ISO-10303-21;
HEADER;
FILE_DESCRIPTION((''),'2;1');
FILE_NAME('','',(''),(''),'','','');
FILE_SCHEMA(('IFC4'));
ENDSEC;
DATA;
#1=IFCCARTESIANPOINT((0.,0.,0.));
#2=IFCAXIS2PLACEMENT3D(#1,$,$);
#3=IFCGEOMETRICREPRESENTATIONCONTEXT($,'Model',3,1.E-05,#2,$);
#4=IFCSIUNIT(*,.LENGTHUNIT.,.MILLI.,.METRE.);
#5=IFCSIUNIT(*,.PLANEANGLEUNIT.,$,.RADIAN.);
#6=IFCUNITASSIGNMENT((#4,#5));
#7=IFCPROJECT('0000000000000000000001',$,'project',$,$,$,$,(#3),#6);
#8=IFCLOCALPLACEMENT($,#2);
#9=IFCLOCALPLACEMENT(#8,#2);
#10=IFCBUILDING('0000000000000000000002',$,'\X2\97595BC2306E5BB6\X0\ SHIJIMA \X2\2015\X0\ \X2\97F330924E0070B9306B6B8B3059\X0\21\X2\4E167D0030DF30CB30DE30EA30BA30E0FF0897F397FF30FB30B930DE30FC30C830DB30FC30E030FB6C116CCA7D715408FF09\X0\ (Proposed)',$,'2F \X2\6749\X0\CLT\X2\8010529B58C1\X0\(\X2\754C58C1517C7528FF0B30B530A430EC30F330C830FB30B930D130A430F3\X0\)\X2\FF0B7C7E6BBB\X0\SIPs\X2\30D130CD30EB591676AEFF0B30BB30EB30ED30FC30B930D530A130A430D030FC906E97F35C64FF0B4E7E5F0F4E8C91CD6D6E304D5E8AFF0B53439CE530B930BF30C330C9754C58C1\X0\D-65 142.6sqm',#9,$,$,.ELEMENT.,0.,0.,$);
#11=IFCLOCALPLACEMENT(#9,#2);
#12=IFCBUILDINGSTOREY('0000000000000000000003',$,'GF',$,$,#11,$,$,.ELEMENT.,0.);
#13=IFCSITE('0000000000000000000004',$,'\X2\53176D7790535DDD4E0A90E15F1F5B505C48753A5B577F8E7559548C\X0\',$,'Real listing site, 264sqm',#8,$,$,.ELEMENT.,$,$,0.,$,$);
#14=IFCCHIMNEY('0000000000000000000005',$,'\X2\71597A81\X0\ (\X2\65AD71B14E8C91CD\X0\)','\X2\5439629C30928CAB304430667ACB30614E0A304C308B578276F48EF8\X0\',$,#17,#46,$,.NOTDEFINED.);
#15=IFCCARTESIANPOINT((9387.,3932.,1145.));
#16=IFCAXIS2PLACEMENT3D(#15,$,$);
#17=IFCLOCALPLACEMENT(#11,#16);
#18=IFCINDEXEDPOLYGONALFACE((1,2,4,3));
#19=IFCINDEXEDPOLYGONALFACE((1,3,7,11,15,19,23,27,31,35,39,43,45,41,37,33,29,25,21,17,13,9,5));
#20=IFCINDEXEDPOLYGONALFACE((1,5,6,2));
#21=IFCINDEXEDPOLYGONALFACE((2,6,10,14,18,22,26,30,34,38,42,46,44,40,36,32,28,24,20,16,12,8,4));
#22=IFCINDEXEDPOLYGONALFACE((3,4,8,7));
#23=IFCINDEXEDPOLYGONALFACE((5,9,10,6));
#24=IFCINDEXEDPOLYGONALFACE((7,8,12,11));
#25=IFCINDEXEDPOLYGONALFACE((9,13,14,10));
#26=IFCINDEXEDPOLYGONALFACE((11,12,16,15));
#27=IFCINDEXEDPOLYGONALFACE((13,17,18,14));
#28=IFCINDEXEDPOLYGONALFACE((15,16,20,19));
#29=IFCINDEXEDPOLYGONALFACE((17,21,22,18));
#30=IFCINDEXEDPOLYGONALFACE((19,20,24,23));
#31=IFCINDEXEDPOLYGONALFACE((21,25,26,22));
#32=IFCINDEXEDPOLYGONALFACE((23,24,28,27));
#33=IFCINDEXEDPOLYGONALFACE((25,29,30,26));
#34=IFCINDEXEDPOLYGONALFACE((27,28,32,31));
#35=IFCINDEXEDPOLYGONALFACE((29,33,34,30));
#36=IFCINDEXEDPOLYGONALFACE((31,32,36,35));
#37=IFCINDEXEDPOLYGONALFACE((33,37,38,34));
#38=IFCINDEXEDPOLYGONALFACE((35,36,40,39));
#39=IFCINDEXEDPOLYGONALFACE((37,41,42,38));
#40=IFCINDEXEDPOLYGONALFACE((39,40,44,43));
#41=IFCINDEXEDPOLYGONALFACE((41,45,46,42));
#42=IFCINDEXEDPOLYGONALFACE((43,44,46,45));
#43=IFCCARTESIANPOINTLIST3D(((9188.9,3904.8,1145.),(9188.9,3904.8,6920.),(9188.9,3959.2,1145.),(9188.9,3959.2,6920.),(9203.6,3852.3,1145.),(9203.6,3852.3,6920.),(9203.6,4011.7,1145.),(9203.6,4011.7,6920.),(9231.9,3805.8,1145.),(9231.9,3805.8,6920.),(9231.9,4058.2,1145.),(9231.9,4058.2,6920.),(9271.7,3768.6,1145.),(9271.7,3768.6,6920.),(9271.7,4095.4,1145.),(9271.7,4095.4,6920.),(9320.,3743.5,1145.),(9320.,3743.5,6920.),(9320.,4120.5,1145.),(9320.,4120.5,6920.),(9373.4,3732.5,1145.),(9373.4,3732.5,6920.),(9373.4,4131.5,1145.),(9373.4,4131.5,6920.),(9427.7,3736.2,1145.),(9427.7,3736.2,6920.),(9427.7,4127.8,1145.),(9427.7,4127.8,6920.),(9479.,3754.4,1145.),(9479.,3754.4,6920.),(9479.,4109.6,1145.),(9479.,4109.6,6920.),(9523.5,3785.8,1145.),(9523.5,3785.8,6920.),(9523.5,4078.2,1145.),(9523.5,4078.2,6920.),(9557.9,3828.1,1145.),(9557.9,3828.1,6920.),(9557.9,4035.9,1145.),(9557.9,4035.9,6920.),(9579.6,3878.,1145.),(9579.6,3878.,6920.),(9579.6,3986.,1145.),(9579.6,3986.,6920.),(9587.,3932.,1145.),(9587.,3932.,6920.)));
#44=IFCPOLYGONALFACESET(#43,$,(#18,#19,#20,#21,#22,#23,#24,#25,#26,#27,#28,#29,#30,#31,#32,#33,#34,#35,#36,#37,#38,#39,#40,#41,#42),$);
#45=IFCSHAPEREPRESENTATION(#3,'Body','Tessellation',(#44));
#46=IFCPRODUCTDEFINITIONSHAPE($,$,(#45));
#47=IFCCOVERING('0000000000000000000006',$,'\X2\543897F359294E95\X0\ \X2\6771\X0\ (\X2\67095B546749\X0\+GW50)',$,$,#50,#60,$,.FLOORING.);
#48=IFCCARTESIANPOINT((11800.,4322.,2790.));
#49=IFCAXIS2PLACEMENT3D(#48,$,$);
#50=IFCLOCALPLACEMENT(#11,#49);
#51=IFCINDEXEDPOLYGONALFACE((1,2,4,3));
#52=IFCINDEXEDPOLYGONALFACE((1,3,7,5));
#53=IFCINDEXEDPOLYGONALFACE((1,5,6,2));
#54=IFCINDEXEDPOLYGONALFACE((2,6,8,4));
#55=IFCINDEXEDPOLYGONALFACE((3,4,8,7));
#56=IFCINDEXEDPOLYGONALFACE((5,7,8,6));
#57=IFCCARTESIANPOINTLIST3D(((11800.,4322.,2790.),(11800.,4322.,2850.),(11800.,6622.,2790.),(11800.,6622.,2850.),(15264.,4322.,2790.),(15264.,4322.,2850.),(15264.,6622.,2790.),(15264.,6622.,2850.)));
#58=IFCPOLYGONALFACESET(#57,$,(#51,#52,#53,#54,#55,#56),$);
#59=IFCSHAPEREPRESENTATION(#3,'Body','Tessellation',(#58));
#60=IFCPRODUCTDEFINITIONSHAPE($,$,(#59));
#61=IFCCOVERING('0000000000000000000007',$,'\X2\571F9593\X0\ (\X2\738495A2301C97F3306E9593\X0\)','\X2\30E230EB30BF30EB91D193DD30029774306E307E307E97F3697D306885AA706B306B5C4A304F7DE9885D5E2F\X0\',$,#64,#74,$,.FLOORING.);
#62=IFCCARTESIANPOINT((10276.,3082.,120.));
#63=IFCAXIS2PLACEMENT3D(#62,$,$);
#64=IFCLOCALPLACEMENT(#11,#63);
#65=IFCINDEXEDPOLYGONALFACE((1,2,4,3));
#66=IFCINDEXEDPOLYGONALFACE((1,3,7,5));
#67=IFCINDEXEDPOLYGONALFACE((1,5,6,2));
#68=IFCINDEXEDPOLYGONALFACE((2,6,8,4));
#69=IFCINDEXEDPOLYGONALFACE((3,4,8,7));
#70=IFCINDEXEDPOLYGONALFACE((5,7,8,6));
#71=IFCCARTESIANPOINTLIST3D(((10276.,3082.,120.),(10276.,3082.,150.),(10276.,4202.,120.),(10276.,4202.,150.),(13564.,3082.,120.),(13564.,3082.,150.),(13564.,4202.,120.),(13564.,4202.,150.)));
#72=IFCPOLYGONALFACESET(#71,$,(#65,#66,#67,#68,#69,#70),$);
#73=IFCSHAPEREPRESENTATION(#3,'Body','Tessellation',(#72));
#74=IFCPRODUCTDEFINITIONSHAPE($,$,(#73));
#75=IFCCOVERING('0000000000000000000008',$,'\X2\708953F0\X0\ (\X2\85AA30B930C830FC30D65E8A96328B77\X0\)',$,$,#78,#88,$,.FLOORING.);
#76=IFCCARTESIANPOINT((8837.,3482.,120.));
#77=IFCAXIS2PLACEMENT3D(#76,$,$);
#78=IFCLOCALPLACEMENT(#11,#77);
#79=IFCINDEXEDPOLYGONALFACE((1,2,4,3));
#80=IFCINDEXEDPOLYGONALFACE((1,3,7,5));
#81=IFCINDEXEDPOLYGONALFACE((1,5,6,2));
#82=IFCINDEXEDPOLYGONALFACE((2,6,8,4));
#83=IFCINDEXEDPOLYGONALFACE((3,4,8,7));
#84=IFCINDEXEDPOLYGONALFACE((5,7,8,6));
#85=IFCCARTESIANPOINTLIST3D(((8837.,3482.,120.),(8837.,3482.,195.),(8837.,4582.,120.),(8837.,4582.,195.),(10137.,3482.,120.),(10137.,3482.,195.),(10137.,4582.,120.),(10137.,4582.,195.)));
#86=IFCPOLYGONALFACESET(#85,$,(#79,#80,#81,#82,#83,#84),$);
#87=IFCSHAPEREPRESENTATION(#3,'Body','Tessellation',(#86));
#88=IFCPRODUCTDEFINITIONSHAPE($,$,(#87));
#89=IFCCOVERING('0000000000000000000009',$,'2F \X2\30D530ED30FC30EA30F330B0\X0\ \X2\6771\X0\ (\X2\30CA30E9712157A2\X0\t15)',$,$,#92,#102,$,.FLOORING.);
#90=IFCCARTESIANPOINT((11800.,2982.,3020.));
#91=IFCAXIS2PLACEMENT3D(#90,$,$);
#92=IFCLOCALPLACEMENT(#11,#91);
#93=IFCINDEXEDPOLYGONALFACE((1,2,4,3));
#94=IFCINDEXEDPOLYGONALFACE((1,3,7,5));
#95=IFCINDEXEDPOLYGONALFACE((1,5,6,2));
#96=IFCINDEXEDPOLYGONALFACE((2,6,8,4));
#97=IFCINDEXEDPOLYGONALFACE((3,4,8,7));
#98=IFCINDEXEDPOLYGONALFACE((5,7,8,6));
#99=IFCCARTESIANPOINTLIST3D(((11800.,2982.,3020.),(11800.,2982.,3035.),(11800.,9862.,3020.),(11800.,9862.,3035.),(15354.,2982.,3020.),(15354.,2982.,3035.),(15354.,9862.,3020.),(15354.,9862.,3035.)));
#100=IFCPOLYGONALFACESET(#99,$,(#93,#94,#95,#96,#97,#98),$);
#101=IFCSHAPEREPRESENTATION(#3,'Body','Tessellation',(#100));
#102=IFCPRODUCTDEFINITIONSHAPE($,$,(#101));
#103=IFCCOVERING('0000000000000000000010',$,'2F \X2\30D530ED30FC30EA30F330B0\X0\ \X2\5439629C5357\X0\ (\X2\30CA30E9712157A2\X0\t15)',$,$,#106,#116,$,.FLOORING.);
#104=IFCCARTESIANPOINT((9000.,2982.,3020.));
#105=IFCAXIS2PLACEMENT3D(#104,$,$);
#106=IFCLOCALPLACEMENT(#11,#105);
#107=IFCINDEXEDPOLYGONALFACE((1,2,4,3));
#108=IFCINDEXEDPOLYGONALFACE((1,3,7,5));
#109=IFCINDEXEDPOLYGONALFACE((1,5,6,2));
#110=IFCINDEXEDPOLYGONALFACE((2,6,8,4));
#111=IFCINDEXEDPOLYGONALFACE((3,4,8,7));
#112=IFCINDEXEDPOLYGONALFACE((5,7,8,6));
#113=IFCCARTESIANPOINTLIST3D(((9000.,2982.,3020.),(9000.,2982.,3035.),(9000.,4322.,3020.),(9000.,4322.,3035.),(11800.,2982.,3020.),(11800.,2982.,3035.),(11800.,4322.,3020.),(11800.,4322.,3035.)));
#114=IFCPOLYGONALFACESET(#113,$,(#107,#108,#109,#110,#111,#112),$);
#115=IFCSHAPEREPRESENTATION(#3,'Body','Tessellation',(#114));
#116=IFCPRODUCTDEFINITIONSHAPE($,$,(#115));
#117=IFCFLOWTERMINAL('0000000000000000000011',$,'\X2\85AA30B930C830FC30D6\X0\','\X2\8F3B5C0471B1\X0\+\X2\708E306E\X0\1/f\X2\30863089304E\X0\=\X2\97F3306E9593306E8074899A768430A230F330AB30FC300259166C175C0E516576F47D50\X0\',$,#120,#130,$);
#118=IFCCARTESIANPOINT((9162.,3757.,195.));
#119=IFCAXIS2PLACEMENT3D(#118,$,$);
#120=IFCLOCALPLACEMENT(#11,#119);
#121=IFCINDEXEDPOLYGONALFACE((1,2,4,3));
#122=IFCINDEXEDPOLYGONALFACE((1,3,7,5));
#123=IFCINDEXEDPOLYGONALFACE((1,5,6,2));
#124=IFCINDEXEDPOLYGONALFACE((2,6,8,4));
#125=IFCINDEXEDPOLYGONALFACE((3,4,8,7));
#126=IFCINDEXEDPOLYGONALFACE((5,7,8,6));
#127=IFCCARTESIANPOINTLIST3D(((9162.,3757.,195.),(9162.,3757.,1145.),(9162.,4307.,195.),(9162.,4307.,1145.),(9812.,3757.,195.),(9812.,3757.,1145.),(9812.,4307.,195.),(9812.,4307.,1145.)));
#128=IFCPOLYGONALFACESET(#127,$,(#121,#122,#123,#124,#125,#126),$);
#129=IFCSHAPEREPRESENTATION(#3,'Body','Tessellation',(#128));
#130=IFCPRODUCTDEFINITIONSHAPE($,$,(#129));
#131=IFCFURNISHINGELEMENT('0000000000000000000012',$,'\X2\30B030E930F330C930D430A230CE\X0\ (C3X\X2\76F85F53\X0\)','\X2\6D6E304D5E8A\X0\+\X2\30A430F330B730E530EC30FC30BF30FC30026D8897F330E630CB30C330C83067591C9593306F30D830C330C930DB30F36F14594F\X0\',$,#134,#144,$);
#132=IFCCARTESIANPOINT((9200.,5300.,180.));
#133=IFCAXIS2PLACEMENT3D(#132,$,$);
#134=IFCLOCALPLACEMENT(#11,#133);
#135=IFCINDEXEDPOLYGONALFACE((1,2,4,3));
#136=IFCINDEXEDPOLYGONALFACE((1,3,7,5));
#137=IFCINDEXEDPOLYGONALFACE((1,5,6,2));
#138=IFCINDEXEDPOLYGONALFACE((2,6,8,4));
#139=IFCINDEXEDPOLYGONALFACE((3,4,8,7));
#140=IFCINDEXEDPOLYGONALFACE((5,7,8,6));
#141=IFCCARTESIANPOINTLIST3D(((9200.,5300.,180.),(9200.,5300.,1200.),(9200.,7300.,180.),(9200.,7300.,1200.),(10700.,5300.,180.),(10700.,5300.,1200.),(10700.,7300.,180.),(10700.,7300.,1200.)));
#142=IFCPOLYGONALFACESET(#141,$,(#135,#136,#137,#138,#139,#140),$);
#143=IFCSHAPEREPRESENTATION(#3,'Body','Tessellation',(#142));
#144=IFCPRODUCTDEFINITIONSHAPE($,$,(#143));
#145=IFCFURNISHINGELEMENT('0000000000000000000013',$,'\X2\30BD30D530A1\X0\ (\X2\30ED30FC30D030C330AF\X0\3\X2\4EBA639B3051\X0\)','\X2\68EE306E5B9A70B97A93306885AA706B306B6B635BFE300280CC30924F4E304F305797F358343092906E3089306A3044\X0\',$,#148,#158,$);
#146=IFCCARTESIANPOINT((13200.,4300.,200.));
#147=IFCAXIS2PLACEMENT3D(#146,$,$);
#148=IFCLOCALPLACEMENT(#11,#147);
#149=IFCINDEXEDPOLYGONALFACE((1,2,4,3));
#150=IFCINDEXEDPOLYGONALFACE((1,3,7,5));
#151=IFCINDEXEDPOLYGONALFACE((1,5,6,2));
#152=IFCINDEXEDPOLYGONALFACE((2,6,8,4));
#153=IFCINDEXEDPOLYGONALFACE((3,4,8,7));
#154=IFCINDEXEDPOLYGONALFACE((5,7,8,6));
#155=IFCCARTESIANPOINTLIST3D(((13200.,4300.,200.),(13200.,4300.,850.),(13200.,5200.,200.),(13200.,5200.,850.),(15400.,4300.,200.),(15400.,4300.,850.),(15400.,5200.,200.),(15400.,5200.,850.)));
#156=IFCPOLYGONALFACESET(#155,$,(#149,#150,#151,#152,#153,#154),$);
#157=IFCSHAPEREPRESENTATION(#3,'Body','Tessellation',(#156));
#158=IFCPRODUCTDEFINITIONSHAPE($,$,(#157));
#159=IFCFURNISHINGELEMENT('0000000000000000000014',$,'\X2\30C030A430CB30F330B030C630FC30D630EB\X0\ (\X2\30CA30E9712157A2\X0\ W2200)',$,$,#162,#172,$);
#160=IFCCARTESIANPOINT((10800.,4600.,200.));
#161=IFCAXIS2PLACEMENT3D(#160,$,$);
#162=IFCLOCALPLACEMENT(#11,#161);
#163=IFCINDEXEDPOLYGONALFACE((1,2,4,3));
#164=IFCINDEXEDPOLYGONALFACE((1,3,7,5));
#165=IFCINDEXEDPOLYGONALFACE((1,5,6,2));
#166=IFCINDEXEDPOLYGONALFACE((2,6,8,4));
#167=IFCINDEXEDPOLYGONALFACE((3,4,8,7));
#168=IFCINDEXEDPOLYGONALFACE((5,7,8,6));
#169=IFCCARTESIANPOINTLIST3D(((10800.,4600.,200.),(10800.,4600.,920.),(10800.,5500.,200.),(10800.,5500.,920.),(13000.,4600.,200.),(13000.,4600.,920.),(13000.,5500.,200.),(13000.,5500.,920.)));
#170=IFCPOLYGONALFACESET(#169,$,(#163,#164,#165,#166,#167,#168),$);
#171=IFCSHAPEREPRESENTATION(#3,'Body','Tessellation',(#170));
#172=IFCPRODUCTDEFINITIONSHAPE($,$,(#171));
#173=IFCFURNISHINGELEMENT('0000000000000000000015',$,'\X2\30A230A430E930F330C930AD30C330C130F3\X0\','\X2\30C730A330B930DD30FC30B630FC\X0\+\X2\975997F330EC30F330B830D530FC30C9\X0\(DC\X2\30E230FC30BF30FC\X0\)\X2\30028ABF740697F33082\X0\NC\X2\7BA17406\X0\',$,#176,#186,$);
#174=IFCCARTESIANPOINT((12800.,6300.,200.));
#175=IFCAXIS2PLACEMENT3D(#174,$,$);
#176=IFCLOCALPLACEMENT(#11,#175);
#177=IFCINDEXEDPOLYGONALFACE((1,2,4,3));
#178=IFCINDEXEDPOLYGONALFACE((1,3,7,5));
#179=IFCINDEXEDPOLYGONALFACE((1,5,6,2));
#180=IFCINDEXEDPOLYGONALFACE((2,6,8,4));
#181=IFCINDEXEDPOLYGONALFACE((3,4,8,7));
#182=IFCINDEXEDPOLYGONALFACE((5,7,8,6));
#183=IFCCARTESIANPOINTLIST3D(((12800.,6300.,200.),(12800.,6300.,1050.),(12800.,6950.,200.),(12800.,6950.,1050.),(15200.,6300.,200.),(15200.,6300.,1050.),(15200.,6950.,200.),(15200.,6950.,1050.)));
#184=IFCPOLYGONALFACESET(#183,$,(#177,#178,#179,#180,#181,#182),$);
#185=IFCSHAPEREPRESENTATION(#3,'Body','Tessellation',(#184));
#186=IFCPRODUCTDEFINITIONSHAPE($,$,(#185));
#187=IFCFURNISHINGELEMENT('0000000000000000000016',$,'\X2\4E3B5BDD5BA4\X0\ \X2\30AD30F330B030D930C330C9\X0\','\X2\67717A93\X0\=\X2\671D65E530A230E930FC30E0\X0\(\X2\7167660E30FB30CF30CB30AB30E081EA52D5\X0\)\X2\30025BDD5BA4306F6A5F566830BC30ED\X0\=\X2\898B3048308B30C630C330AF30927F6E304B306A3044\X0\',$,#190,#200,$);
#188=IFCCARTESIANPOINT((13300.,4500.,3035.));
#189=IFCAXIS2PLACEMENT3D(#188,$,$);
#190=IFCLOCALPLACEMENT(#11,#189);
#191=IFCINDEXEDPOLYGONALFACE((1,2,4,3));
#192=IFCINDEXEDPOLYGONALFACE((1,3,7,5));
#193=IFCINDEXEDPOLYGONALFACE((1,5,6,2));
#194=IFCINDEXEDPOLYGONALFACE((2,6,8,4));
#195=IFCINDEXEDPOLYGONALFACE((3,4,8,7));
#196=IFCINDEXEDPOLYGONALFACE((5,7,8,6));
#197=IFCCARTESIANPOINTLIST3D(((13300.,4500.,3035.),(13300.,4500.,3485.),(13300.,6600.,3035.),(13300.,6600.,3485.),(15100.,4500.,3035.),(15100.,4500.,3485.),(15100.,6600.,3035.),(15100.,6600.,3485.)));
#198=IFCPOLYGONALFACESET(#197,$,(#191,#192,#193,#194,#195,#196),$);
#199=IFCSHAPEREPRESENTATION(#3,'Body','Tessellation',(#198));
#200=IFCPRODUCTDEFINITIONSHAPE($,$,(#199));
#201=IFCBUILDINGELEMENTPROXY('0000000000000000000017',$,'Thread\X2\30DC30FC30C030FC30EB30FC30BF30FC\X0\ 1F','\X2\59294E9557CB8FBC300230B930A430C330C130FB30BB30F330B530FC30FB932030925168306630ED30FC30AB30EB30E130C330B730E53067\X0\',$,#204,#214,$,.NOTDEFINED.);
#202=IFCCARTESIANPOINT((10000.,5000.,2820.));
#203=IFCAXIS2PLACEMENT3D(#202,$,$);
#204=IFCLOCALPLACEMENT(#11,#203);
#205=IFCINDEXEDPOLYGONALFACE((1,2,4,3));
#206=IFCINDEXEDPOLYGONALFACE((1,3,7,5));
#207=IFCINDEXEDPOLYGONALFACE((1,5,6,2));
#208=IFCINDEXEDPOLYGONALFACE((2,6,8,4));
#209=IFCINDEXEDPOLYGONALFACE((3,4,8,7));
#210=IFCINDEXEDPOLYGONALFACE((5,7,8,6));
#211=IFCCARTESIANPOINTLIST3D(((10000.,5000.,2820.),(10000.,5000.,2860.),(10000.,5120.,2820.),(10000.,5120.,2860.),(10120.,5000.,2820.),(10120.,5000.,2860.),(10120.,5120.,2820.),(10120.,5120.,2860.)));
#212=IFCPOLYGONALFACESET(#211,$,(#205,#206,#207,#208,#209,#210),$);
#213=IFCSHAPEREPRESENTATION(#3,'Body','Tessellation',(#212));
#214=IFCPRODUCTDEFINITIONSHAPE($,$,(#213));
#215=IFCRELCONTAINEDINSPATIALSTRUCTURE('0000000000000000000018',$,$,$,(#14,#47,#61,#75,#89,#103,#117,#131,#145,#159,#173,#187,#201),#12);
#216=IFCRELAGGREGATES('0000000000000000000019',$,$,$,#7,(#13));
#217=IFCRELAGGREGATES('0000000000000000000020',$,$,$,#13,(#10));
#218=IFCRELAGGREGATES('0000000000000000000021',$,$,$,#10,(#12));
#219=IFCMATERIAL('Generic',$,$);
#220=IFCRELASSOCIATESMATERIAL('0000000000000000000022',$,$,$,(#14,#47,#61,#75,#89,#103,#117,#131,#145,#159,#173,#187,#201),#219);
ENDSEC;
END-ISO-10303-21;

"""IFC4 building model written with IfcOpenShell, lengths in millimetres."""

from ifc_helpers import new_model, si_unit, frame, frame_2d, origin, origin_2d, place, context, project, spatial, rectangle, circle, extrude, material, element, save


model = new_model("IFC4")

# Units and contexts
model_context = context("Model", 3, precision=1e-05, world=origin())
ifc_project = project(units=[si_unit("LENGTHUNIT", "METRE", prefix="MILLI"), si_unit("PLANEANGLEUNIT", "RADIAN")], contexts=[model_context])

# Site, building, storey
site_placement = place(None, origin())
site = spatial("IfcSite", under=ifc_project, at=site_placement, Name="北海道川上郡弟子屈町字美留和", ObjectType="Real listing site, 264sqm", CompositionType="ELEMENT", RefElevation=0.0)
building_placement = place(site_placement, origin())
building = spatial("IfcBuilding", under=site, at=building_placement, Name="静寂の家 SHIJIMA ― 音を一点に残す21世紀ミニマリズム（音響・スマートホーム・民泊統合） (Proposed)", ObjectType="2F 杉CLT耐力壁(界壁兼用＋サイレント・スパイン)＋籾殻SIPsパネル外皮＋セルロースファイバー遮音層＋乾式二重浮き床＋千鳥スタッド界壁D-65 142.6sqm", CompositionType="ELEMENT", ElevationOfRefHeight=0.0, ElevationOfTerrain=0.0)
storey_placement = place(building_placement, origin())
storey = spatial("IfcBuildingStorey", under=building, at=storey_placement, Name="GF", CompositionType="ELEMENT", Elevation=0.0)

# Shared definitions
ifc_material = material(Name="Generic")

# Chimney
chimney_placement = place(storey_placement, frame((9387.0, 3932.0, 1145.0)))
element("IfcChimney", 1, at=chimney_placement, inside=storey, material=ifc_material, Name="煙突 (断熱二重)", Description="吹抜を貫いて立ち上がる垂直軸", PredefinedType="NOTDEFINED", context=model_context, shape_type="SweptSolid", body=[
    extrude(circle(Radius=200.0, at=origin_2d()), frame((9387.0, 3932.0, 1145.0)), (0.0, 0.0, 1.0), 5775.0),
])

# Coverings
covering_1_placement = place(storey_placement, frame((11800.0, 4322.0, 2790.0)))
element("IfcCovering", 2, at=covering_1_placement, inside=storey, material=ifc_material, Name="吸音天井 東 (有孔杉+GW50)", PredefinedType="FLOORING", context=model_context, shape_type="SweptSolid", body=[
    extrude(rectangle(XDim=3464.0, YDim=2300.0, at=frame_2d((1732.0, 1150.0))), frame((11800.0, 4322.0, 2790.0)), (0.0, 0.0, 1.0), 60.0),
])
covering_2_placement = place(storey_placement, frame((10276.0, 3082.0, 120.0)))
element("IfcCovering", 3, at=covering_2_placement, inside=storey, material=ifc_material, Name="土間 (玄関〜音の間)", Description="モルタル金鏝。靴のまま音楽と薪火に届く緩衝帯", PredefinedType="FLOORING", context=model_context, shape_type="SweptSolid", body=[
    extrude(rectangle(XDim=3288.0, YDim=1120.0, at=frame_2d((1644.0, 560.0))), frame((10276.0, 3082.0, 120.0)), (0.0, 0.0, 1.0), 30.0),
])
covering_3_placement = place(storey_placement, frame((8837.0, 3482.0, 120.0)))
element("IfcCovering", 4, at=covering_3_placement, inside=storey, material=ifc_material, Name="炉台 (薪ストーブ床防護)", PredefinedType="FLOORING", context=model_context, shape_type="SweptSolid", body=[
    extrude(rectangle(XDim=1300.0, YDim=1100.0, at=frame_2d((650.0, 550.0))), frame((8837.0, 3482.0, 120.0)), (0.0, 0.0, 1.0), 75.0),
])
covering_4_placement = place(storey_placement, frame((11800.0, 2982.0, 3020.0)))
element("IfcCovering", 5, at=covering_4_placement, inside=storey, material=ifc_material, Name="2F フローリング 東 (ナラ無垢t15)", PredefinedType="FLOORING", context=model_context, shape_type="SweptSolid", body=[
    extrude(rectangle(XDim=3554.0, YDim=6880.0, at=frame_2d((1777.0, 3440.0))), frame((11800.0, 2982.0, 3020.0)), (0.0, 0.0, 1.0), 15.0),
])
covering_5_placement = place(storey_placement, frame((9000.0, 2982.0, 3020.0)))
element("IfcCovering", 6, at=covering_5_placement, inside=storey, material=ifc_material, Name="2F フローリング 吹抜南 (ナラ無垢t15)", PredefinedType="FLOORING", context=model_context, shape_type="SweptSolid", body=[
    extrude(rectangle(XDim=2800.0, YDim=1340.0, at=frame_2d((1400.0, 670.0))), frame((9000.0, 2982.0, 3020.0)), (0.0, 0.0, 1.0), 15.0),
])

# Flow terminal
flow_terminal_placement = place(storey_placement, frame((9162.0, 3757.0, 195.0)))
element("IfcFlowTerminal", 7, at=flow_terminal_placement, inside=storey, material=ifc_material, Name="薪ストーブ", Description="輻射熱+炎の1/fゆらぎ=音の間の聴覚的アンカー。外気導入直結", context=model_context, shape_type="SweptSolid", body=[
    extrude(rectangle(XDim=650.0, YDim=550.0, at=frame_2d((325.0, 275.0))), frame((9162.0, 3757.0, 195.0)), (0.0, 0.0, 1.0), 950.0),
])

# Furnishing elements
furnishing_1_placement = place(storey_placement, frame((9200.0, 5300.0, 180.0)))
element("IfcFurnishingElement", 8, at=furnishing_1_placement, inside=storey, material=ifc_material, Name="グランドピアノ (C3X相当)", Description="浮き床+インシュレーター。消音ユニットで夜間はヘッドホン演奏", context=model_context, shape_type="SweptSolid", body=[
    extrude(rectangle(XDim=1500.0, YDim=2000.0, at=frame_2d((750.0, 1000.0))), frame((9200.0, 5300.0, 180.0)), (0.0, 0.0, 1.0), 1020.0),
])
furnishing_2_placement = place(storey_placement, frame((13200.0, 4300.0, 200.0)))
element("IfcFurnishingElement", 9, at=furnishing_2_placement, inside=storey, material=ifc_material, Name="ソファ (ローバック3人掛け)", Description="森の定点窓と薪火に正対。背を低くし音場を遮らない", context=model_context, shape_type="SweptSolid", body=[
    extrude(rectangle(XDim=2200.0, YDim=900.0, at=frame_2d((1100.0, 450.0))), frame((13200.0, 4300.0, 200.0)), (0.0, 0.0, 1.0), 650.0),
])
furnishing_3_placement = place(storey_placement, frame((10800.0, 4600.0, 200.0)))
element("IfcFurnishingElement", 10, at=furnishing_3_placement, inside=storey, material=ifc_material, Name="ダイニングテーブル (ナラ無垢 W2200)", context=model_context, shape_type="SweptSolid", body=[
    extrude(rectangle(XDim=2200.0, YDim=900.0, at=frame_2d((1100.0, 450.0))), frame((10800.0, 4600.0, 200.0)), (0.0, 0.0, 1.0), 720.0),
])
furnishing_4_placement = place(storey_placement, frame((12800.0, 6300.0, 200.0)))
element("IfcFurnishingElement", 11, at=furnishing_4_placement, inside=storey, material=ifc_material, Name="アイランドキッチン", Description="ディスポーザー+静音レンジフード(DCモーター)。調理音もNC管理", context=model_context, shape_type="SweptSolid", body=[
    extrude(rectangle(XDim=2400.0, YDim=650.0, at=frame_2d((1200.0, 325.0))), frame((12800.0, 6300.0, 200.0)), (0.0, 0.0, 1.0), 850.0),
])
furnishing_5_placement = place(storey_placement, frame((13300.0, 4500.0, 3035.0)))
element("IfcFurnishingElement", 12, at=furnishing_5_placement, inside=storey, material=ifc_material, Name="主寝室 キングベッド", Description="東窓=朝日アラーム(照明・ハニカム自動)。寝室は機器ゼロ=見えるテックを置かない", context=model_context, shape_type="SweptSolid", body=[
    extrude(rectangle(XDim=1800.0, YDim=2100.0, at=frame_2d((900.0, 1050.0))), frame((13300.0, 4500.0, 3035.0)), (0.0, 0.0, 1.0), 450.0),
])

# Building element proxy
proxy_1_placement = place(storey_placement, frame((10000.0, 5000.0, 2820.0)))
element("IfcBuildingElementProxy", 13, at=proxy_1_placement, inside=storey, material=ifc_material, Name="Threadボーダールーター 1F", Description="天井埋込。スイッチ・センサー・錠を全てローカルメッシュで", PredefinedType="NOTDEFINED", context=model_context, shape_type="SweptSolid", body=[
    extrude(rectangle(XDim=120.0, YDim=120.0, at=frame_2d((60.0, 60.0))), frame((10000.0, 5000.0, 2820.0)), (0.0, 0.0, 1.0), 40.0),
])

save(model, "model.ifc")
